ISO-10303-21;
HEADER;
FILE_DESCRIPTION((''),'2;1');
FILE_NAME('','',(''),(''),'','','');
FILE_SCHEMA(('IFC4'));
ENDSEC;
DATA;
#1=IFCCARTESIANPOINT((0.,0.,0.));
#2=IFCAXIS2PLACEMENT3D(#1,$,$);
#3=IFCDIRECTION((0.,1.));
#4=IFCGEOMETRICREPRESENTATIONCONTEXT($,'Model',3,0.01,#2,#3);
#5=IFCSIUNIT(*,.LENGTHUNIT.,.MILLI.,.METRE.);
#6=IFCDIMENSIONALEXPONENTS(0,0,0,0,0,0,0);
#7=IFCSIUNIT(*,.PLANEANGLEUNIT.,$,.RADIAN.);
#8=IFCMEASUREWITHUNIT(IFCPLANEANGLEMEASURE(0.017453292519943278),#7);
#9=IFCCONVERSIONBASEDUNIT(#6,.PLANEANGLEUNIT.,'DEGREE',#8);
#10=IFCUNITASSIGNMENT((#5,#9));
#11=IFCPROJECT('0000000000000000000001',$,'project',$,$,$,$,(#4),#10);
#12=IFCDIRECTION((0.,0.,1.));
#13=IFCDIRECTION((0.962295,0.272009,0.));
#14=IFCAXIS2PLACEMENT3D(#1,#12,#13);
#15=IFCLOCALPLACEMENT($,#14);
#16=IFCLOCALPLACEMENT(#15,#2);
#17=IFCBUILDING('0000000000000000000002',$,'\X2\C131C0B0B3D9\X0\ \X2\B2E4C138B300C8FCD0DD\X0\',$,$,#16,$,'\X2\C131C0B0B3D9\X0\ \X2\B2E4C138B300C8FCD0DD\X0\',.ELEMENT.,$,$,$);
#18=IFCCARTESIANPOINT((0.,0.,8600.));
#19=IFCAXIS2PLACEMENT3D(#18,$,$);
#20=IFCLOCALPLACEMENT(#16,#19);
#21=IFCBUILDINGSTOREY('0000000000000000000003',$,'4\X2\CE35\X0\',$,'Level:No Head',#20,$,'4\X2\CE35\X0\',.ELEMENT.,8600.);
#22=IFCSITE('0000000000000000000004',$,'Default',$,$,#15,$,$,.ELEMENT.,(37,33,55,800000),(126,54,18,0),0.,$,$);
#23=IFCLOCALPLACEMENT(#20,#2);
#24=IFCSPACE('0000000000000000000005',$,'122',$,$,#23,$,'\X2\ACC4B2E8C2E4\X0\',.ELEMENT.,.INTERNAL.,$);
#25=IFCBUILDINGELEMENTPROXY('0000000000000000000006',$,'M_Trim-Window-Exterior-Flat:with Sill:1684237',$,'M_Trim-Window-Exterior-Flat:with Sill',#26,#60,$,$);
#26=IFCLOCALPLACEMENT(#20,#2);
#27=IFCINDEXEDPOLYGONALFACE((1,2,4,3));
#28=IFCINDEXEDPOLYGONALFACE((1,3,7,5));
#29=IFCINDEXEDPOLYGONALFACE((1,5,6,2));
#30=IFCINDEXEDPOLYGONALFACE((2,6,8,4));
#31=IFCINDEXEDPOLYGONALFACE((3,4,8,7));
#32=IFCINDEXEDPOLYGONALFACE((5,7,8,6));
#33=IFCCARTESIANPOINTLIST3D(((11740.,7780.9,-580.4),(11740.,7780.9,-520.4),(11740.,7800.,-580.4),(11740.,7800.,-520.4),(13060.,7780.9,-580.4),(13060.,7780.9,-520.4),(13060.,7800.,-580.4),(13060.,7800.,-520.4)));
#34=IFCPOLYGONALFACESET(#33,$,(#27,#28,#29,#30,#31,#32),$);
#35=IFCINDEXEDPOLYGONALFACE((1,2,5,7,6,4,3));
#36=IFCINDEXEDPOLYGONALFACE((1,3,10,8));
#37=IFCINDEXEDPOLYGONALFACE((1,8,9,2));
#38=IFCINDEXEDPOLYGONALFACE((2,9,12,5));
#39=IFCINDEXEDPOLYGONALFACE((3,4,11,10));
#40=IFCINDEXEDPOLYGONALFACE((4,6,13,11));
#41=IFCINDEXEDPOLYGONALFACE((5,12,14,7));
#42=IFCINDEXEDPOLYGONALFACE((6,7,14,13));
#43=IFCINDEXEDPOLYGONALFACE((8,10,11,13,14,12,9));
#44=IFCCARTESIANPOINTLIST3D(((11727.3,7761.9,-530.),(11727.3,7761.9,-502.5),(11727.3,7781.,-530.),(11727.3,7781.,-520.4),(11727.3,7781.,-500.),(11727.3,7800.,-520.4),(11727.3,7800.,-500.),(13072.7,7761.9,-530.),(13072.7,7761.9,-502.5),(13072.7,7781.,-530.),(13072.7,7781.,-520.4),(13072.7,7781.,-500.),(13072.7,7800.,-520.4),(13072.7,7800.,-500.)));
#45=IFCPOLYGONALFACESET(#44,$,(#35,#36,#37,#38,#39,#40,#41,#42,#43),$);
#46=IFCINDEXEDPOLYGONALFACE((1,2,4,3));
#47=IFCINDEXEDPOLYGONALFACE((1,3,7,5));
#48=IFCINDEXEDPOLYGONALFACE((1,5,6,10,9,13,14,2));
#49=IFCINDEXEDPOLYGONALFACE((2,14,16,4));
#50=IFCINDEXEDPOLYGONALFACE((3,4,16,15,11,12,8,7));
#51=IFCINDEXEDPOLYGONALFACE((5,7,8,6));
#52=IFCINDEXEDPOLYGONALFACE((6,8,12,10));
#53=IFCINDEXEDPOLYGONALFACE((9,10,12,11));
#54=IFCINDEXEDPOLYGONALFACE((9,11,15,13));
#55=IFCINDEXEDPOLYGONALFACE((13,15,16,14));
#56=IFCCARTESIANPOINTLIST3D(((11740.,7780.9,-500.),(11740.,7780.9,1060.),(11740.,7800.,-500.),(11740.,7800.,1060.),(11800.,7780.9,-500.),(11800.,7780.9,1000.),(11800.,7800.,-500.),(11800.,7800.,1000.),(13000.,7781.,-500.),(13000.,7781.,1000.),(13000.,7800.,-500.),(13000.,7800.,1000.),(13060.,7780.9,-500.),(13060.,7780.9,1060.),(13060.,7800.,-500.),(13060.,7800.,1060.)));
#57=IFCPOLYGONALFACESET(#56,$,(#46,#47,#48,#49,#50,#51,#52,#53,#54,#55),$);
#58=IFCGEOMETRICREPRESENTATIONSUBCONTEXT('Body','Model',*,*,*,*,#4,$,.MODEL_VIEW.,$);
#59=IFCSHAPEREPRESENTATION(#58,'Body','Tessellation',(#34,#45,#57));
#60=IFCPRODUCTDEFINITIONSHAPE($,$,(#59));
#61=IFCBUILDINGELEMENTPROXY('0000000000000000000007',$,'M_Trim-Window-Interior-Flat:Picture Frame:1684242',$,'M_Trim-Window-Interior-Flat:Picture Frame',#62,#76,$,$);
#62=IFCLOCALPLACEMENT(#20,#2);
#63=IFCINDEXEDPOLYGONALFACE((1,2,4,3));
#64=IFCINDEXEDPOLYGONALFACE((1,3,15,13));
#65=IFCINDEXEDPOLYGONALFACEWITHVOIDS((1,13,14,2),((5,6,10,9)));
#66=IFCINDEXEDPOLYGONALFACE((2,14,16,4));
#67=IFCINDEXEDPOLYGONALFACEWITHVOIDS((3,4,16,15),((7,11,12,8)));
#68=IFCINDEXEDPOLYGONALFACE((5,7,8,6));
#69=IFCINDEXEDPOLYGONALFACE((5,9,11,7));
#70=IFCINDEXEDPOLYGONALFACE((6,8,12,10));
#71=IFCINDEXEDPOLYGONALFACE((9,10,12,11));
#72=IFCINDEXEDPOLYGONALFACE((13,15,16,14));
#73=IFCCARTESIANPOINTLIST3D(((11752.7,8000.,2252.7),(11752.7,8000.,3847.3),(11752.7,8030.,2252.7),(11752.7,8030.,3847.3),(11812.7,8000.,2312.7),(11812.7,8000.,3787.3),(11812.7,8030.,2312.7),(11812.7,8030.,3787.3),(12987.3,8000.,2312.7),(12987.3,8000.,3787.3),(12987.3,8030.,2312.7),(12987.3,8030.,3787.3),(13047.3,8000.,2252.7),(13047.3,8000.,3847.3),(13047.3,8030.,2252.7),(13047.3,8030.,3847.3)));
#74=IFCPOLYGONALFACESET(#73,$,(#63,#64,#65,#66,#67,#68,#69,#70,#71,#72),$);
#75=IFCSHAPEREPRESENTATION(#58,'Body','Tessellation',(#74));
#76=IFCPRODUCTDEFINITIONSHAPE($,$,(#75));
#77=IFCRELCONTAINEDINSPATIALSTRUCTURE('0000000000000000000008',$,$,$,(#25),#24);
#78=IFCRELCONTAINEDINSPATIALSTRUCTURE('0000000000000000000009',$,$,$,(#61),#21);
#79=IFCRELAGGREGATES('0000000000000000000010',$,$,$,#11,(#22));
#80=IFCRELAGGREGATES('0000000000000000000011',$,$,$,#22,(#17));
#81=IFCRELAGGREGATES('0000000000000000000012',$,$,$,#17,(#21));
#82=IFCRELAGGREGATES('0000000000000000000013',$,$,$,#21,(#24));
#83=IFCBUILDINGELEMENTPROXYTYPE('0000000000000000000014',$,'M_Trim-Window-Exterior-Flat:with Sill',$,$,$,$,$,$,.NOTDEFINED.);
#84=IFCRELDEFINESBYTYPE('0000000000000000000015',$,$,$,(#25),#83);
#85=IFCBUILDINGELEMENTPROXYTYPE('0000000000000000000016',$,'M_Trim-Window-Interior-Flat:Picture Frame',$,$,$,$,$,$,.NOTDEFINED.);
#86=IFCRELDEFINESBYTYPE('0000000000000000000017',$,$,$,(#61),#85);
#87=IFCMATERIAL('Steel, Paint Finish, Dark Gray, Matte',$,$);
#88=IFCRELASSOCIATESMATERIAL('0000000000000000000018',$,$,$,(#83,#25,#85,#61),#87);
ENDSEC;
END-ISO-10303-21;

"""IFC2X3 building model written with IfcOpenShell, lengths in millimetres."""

from ifc_helpers import new_model, entity, si_unit, converted_unit, direction, frame, frame_2d, origin, place, context, subcontext, project, spatial, polyline, rectangle, outline, extrude, source, transform, mapped, material, type_object, type_shapes, element, save


model = new_model("IFC2X3")

# Units and contexts
model_context = context("Model", 3, precision=0.01, world=origin(), true_north=direction((0.0, 1.0)))
body_context = subcontext(model_context, "Body", "Model", "MODEL_VIEW")
ifc_project = project(units=[si_unit("LENGTHUNIT", "METRE", prefix="MILLI"), converted_unit("PLANEANGLEUNIT", "DEGREE", entity("IfcPlaneAngleMeasure", 0.017453292519943278), si_unit("PLANEANGLEUNIT", "RADIAN"), dimensions=[0, 0, 0, 0, 0, 0, 0])], contexts=[model_context])

# Site, building, storey
site_placement = place(None, frame((0.0, 0.0, 0.0), z_axis=(0.0, 0.0, 1.0), x_axis=(0.962295, 0.272009, 0.0)))
site = spatial("IfcSite", under=ifc_project, at=site_placement, Name="Default", CompositionType="ELEMENT", RefLatitude=(37, 33, 55, 800000), RefLongitude=(126, 54, 18, 0), RefElevation=0.0)
building_placement = place(site_placement, origin())
building = spatial("IfcBuilding", under=site, at=building_placement, Name="성산동 다세대주택", LongName="성산동 다세대주택", CompositionType="ELEMENT")
storey_placement = place(building_placement, frame((0.0, 0.0, 8600.0)))
storey = spatial("IfcBuildingStorey", under=building, at=storey_placement, Name="4층", ObjectType="Level:No Head", LongName="4층", CompositionType="ELEMENT", Elevation=8600.0)

# Shared definitions
ifc_material_1 = material(Name="Steel, Paint Finish, Dark Gray, Matte")

# Shared definitions
space_1_placement = place(storey_placement, origin())
space_1 = spatial("IfcSpace", under=storey, at=space_1_placement, Name="122", LongName="계단실", CompositionType="ELEMENT", InteriorOrExteriorSpace="INTERNAL")

# Building element proxies
building_element_proxy_type_1 = type_object("IfcBuildingElementProxyType", Name="M_Trim-Window-Exterior-Flat:with Sill", PredefinedType="NOTDEFINED", material=ifc_material_1)
shared_shape_1 = source(origin(), body_context, "Body", "SweptSolid", [
    extrude(rectangle(XDim=1320.0, YDim=60.0, at=frame_2d((0.0, 0.0), x_axis=(1.0, 0.0))), frame((0.0, -1550.4, 0.0), z_axis=(0.0, 0.0, 1.0), x_axis=(-1.0, 0.0, 0.0)), (0.0, 0.0, 1.0), 19.0),
    extrude(outline(polyline([(-19.0, -15.2), (0.0, -15.2), (0.0, -5.7), (19.0, -5.7), (19.0, 14.8), (0.0, 14.8), (-19.0, 12.3), (-19.0, -15.2)])), frame((-672.7, -1514.8, 19.0), z_axis=(1.0, 0.0, 0.0), x_axis=(0.0, 0.0, -1.0)), (0.0, 0.0, 1.0), 1345.4),
    extrude(outline(polyline([(-795.0, -660.0), (765.0, -660.0), (765.0, -600.0), (-735.0, -600.0), (-735.0, 600.0), (765.0, 600.0), (765.0, 660.0), (-795.0, 660.0), (-795.0, -660.0)])), frame((0.0, -735.0, 0.0), z_axis=(0.0, 0.0, 1.0), x_axis=(0.0, -1.0, 0.0)), (0.0, 0.0, 1.0), 19.0),
])
type_shapes(building_element_proxy_type_1, [shared_shape_1])
proxy_1_placement = place(space_1_placement, frame((12400.0, 7800.0, 1000.0), z_axis=(0.0, -1.0, 0.0), x_axis=(1.0, 0.0, 0.0)))
element("IfcBuildingElementProxy", 1, at=proxy_1_placement, inside=space_1, type_object=building_element_proxy_type_1, material=ifc_material_1, Name="M_Trim-Window-Exterior-Flat:with Sill:1684237", ObjectType="M_Trim-Window-Exterior-Flat:with Sill", context=body_context, shape_type="MappedRepresentation", body=[
    mapped(shared_shape_1, transform((0.0, 0.0, 0.0), scale=1.0)),
])
building_element_proxy_type_2 = type_object("IfcBuildingElementProxyType", Name="M_Trim-Window-Interior-Flat:Picture Frame", PredefinedType="NOTDEFINED", material=ifc_material_1)
shared_shape_2 = source(origin(), body_context, "Body", "SweptSolid", [
    extrude(outline(polyline([(-647.3, -797.3), (647.3, -797.3), (647.3, 797.3), (-647.3, 797.3), (-647.3, -797.3)]), holes=[polyline([(-587.3, -737.3), (-587.3, 737.3), (587.3, 737.3), (587.3, -737.3), (-587.3, -737.3)])]), frame((0.0, -750.0, 0.0), z_axis=(0.0, 0.0, 1.0), x_axis=(-1.0, 0.0, 0.0)), (0.0, 0.0, 1.0), 30.0),
])
type_shapes(building_element_proxy_type_2, [shared_shape_2])
proxy_2_placement = place(storey_placement, frame((12400.0, 8000.0, 3800.0), z_axis=(0.0, 1.0, 0.0), x_axis=(-1.0, 0.0, 0.0)))
element("IfcBuildingElementProxy", 2, at=proxy_2_placement, inside=storey, type_object=building_element_proxy_type_2, material=ifc_material_1, Name="M_Trim-Window-Interior-Flat:Picture Frame:1684242", ObjectType="M_Trim-Window-Interior-Flat:Picture Frame", context=body_context, shape_type="MappedRepresentation", body=[
    mapped(shared_shape_2, transform((0.0, 0.0, 0.0), scale=1.0)),
])

save(model, "model.ifc")
